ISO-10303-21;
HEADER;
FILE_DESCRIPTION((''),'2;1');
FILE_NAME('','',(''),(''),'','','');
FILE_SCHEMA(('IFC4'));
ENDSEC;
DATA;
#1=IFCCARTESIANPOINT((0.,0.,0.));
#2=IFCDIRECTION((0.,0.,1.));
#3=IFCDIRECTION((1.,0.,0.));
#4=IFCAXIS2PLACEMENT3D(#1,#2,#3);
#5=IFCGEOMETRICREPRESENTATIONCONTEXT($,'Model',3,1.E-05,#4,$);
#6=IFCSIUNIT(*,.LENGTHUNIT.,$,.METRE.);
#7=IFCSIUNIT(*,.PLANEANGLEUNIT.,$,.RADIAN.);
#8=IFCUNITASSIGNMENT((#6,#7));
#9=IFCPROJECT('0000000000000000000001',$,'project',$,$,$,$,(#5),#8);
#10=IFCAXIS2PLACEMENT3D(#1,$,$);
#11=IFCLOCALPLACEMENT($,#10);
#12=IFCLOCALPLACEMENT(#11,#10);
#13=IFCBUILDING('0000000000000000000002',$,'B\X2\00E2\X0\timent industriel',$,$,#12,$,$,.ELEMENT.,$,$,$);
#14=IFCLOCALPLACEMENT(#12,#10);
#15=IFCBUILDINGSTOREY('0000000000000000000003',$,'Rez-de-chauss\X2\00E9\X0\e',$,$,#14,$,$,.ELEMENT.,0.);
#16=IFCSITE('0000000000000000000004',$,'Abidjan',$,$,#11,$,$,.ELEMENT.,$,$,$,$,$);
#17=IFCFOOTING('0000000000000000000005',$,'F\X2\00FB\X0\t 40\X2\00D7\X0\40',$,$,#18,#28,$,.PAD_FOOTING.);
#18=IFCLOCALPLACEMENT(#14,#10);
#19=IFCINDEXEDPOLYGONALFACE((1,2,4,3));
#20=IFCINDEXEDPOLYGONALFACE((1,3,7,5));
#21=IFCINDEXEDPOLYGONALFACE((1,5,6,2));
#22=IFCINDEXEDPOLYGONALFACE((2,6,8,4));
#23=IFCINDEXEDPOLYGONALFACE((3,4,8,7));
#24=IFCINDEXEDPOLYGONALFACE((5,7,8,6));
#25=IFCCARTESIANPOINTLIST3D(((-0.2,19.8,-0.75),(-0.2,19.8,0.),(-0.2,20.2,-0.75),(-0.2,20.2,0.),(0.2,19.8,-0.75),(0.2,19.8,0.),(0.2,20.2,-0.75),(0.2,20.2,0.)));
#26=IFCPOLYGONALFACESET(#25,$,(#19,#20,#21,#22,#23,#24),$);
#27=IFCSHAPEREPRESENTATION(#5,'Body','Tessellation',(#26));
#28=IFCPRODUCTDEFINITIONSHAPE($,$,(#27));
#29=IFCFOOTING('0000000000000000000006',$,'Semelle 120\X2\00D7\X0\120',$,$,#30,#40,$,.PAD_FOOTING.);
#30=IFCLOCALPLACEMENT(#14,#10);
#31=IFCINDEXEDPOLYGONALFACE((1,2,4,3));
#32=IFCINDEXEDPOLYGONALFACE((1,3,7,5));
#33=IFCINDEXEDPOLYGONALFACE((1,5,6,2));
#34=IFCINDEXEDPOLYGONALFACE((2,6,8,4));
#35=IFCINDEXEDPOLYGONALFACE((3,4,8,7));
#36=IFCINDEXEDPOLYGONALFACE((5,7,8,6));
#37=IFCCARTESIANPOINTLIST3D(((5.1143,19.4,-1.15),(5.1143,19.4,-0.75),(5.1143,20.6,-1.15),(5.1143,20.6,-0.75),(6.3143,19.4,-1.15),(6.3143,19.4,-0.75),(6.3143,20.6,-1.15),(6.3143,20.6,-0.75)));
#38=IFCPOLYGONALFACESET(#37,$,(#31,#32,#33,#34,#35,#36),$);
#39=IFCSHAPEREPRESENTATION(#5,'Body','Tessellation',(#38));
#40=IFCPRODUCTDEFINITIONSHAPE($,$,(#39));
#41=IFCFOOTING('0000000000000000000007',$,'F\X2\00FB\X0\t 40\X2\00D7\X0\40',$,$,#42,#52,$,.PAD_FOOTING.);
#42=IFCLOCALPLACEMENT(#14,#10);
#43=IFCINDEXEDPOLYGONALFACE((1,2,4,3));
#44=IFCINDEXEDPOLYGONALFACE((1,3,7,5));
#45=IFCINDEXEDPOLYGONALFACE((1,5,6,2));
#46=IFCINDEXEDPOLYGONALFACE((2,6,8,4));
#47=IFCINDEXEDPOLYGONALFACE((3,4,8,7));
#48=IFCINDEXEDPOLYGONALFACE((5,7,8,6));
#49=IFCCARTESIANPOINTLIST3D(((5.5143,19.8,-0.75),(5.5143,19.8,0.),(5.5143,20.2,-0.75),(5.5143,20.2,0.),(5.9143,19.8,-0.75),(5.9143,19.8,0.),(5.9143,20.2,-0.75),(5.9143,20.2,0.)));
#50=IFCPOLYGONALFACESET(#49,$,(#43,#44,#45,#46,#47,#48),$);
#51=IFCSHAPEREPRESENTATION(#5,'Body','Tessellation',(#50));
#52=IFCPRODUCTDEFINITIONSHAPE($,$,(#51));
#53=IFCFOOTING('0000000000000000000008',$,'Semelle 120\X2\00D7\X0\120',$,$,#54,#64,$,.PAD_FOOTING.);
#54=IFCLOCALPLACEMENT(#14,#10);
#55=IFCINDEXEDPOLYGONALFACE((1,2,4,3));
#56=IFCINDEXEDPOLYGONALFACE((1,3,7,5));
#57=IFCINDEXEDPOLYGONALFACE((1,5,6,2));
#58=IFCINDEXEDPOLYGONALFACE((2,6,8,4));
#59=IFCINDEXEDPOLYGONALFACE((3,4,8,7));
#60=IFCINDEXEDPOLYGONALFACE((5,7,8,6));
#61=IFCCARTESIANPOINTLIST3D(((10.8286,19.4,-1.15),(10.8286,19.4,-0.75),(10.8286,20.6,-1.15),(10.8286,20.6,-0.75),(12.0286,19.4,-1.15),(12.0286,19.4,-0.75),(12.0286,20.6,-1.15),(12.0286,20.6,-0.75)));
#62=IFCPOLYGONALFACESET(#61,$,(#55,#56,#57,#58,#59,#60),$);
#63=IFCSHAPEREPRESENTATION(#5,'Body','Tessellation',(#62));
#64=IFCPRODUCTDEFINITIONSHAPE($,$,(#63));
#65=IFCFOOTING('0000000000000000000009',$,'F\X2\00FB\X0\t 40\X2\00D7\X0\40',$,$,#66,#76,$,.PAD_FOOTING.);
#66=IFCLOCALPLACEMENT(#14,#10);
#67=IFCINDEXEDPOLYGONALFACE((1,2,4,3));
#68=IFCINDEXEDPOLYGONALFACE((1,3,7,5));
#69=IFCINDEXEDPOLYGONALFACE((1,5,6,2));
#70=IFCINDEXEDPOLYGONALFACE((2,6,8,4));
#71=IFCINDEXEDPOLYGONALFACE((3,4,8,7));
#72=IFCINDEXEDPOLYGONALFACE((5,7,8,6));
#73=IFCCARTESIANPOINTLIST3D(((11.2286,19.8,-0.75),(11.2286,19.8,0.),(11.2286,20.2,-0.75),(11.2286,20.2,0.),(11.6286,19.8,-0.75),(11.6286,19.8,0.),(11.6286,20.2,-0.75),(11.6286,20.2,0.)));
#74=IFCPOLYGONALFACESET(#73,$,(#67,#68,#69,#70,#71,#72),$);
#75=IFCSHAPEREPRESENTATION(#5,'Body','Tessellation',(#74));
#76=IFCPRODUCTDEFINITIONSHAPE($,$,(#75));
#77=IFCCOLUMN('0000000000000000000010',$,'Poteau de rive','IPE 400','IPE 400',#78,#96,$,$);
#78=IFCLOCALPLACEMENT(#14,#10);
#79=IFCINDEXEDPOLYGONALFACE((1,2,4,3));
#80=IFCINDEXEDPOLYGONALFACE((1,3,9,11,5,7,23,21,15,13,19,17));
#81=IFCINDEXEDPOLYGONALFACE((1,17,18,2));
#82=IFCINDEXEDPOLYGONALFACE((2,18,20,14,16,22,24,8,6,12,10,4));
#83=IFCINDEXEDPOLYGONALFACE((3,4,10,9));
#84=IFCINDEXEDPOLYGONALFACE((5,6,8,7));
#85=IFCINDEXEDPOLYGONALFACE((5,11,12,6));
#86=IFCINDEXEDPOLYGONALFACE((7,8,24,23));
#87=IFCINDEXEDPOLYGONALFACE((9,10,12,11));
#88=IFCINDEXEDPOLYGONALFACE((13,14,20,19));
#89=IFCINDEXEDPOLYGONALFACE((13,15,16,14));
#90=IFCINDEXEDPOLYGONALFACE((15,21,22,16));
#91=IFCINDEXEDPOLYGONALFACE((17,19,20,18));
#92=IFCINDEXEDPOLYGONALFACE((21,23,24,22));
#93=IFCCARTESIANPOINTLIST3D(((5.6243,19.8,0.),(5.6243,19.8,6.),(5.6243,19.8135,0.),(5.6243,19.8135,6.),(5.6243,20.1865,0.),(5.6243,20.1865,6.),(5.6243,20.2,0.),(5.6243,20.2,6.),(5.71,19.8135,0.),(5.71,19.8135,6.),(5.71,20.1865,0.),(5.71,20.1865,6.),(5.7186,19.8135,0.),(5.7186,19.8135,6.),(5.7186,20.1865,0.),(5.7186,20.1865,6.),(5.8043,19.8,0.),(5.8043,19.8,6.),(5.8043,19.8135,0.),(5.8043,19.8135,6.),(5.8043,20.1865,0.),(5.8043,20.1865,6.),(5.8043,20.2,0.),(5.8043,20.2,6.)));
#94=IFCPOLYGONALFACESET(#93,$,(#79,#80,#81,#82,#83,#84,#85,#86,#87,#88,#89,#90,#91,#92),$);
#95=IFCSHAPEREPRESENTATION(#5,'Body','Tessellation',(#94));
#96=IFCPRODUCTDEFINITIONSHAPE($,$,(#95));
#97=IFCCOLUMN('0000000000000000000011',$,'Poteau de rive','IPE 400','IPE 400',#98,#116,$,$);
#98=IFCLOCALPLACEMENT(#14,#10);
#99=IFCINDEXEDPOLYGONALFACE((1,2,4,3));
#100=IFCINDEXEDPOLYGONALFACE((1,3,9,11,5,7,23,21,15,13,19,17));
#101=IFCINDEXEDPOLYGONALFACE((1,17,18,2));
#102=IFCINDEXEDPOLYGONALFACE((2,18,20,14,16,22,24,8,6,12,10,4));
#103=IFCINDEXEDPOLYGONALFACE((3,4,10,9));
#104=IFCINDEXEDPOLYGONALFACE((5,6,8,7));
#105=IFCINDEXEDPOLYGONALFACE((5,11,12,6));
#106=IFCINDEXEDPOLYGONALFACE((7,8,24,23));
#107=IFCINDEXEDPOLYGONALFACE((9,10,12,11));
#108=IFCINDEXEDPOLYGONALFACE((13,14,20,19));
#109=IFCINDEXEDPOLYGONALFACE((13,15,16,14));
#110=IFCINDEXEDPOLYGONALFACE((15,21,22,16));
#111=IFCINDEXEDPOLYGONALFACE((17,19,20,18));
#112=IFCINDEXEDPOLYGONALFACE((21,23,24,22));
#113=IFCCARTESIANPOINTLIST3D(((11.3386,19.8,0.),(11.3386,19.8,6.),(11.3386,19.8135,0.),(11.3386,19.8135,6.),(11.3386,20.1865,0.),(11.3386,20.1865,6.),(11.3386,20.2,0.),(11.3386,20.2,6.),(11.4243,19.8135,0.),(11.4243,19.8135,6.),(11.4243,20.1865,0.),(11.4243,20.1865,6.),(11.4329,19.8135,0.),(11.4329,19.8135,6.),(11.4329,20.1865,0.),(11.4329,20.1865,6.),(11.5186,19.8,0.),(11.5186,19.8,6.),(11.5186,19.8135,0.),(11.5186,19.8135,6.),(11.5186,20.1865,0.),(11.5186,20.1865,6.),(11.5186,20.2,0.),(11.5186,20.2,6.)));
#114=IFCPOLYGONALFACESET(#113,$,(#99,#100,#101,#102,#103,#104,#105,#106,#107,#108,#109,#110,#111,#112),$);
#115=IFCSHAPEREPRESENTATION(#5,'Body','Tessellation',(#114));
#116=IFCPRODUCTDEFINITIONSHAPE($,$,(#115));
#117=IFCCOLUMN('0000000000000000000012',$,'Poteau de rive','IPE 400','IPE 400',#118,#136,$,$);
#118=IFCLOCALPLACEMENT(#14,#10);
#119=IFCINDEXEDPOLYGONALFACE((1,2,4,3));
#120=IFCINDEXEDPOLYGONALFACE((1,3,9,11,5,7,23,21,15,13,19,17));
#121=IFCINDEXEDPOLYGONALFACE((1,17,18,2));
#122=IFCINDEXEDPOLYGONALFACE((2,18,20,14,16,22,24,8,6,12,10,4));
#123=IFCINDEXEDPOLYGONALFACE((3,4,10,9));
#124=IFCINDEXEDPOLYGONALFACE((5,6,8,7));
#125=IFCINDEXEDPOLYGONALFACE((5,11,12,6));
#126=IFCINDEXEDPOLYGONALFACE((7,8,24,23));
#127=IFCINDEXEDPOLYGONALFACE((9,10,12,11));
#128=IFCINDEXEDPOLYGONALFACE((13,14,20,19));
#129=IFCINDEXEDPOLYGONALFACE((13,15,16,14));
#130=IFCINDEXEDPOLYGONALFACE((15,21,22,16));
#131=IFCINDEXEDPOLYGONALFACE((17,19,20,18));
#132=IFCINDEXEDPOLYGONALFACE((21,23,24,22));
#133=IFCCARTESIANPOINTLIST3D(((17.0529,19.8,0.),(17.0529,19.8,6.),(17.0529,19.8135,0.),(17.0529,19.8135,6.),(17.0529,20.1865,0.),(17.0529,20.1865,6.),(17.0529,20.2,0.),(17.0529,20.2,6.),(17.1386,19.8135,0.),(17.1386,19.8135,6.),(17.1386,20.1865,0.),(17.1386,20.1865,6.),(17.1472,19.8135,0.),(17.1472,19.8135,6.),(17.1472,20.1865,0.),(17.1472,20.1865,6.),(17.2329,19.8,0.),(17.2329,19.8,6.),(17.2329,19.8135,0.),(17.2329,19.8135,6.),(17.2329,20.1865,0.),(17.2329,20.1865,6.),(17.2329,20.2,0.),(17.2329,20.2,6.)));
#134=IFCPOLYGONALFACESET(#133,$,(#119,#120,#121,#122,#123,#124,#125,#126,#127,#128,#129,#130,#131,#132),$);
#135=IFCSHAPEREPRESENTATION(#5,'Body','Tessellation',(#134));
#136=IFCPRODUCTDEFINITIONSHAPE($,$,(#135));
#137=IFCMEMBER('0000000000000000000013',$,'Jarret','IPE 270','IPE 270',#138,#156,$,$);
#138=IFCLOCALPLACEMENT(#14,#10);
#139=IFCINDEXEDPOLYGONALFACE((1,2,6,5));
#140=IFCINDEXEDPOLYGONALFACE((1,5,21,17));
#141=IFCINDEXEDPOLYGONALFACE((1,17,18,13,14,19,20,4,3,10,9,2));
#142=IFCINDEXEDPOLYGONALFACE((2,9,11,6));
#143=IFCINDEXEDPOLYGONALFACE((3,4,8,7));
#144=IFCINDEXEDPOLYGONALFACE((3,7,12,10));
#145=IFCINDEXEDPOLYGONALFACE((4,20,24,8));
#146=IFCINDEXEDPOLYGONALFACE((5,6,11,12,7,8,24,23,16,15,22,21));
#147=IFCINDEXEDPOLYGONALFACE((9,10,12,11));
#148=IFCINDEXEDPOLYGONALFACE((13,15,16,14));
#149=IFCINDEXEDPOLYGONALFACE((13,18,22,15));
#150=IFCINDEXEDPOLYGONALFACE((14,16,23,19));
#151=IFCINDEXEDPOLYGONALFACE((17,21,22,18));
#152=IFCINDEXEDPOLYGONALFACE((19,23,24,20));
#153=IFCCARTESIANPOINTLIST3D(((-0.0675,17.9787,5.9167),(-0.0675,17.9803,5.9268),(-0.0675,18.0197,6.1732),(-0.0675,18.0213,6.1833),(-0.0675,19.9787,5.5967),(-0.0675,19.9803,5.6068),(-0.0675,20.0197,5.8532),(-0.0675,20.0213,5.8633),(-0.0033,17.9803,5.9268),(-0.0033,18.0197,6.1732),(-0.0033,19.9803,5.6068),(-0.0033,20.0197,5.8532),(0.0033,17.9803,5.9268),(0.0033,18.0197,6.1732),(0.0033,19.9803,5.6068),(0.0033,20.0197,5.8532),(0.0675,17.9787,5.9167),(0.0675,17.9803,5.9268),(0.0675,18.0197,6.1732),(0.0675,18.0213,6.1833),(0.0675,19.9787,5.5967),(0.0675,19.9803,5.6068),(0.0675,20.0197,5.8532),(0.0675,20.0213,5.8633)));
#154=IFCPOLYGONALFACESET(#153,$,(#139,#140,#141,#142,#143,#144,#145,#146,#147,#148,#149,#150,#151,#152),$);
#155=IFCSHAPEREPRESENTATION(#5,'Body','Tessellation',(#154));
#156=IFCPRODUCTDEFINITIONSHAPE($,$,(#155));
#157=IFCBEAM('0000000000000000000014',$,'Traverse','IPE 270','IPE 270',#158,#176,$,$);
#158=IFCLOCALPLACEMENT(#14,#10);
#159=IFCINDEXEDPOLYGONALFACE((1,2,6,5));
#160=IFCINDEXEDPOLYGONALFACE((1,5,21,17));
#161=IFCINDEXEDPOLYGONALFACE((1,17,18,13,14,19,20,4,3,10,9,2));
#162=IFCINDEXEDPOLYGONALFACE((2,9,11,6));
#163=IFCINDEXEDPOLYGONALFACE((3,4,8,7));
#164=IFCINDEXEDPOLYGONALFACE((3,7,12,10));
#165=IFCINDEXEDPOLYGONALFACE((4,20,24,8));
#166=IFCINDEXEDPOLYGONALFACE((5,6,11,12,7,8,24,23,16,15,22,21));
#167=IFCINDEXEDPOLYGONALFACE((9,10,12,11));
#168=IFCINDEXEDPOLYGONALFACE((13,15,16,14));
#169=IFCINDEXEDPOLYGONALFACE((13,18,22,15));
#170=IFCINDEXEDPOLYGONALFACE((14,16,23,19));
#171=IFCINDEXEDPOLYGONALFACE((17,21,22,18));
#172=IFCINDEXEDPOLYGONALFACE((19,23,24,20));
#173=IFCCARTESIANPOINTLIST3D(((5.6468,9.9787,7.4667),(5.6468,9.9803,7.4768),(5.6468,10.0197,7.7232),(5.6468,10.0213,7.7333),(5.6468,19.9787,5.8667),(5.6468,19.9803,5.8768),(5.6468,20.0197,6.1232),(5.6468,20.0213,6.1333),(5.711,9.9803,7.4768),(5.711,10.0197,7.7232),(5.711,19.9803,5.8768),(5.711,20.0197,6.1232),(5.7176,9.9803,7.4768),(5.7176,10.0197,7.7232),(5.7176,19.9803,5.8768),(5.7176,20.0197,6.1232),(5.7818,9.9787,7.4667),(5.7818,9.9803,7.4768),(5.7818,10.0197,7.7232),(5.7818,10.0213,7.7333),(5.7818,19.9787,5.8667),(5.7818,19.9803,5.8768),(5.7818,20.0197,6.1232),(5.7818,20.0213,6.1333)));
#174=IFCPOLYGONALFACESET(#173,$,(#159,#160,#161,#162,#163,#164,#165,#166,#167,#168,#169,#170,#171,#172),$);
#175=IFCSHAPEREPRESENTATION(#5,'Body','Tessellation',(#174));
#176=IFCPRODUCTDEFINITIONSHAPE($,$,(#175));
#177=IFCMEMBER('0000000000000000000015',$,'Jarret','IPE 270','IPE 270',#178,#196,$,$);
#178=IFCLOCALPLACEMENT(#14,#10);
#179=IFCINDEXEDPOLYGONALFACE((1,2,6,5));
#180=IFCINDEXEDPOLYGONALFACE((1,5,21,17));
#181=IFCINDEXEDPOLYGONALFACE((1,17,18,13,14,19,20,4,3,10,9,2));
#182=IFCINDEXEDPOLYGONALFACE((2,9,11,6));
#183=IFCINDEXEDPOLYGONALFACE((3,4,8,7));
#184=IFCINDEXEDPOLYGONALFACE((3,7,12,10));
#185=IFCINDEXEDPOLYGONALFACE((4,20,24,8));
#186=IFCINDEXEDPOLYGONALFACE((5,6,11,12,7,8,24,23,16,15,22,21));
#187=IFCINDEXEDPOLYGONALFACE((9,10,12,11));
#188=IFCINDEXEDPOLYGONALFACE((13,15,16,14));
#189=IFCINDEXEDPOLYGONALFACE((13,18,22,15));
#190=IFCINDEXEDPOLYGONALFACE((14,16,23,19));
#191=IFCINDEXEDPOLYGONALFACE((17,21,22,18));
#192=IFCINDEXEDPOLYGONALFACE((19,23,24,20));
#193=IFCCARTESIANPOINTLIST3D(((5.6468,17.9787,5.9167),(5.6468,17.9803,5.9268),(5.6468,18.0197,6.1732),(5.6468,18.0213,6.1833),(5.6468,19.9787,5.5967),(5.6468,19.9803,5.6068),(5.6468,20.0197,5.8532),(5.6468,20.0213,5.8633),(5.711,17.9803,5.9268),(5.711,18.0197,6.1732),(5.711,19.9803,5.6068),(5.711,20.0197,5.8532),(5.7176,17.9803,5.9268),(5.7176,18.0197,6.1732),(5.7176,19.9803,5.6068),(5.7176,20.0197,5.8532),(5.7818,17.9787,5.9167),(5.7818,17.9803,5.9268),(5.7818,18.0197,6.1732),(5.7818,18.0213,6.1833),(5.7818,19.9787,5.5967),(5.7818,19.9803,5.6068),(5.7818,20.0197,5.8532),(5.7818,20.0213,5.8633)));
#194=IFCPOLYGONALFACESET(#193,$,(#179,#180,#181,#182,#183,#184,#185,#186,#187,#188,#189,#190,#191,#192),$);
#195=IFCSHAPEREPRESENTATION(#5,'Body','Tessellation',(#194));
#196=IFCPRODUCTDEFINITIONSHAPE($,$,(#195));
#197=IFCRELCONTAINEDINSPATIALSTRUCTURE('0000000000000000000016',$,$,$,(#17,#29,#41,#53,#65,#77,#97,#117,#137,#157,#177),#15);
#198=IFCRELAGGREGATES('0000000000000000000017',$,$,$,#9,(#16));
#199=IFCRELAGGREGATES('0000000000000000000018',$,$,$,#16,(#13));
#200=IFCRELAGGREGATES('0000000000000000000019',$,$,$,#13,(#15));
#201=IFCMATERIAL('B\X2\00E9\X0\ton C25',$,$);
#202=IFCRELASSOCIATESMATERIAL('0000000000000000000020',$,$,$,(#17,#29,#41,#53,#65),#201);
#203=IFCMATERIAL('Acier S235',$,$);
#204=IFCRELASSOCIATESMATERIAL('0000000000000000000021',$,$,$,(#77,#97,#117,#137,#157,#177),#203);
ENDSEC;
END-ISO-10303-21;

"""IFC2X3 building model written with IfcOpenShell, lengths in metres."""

from ifc_helpers import new_model, si_unit, frame, origin, origin_with_axes, origin_2d, place, context, project, spatial, rectangle, i_section, extrude, material, element, save


model = new_model("IFC2X3")

# Units and contexts
model_context = context("Model", 3, precision=1e-05, world=origin_with_axes())
ifc_project = project(units=[si_unit("LENGTHUNIT", "METRE"), si_unit("PLANEANGLEUNIT", "RADIAN")], contexts=[model_context])

# Site, building, storey
site_placement = place(None, origin())
site = spatial("IfcSite", under=ifc_project, at=site_placement, Name="Abidjan", CompositionType="ELEMENT")
building_placement = place(site_placement, origin())
building = spatial("IfcBuilding", under=site, at=building_placement, Name="Bâtiment industriel", CompositionType="ELEMENT")
storey_placement = place(building_placement, origin())
storey = spatial("IfcBuildingStorey", under=building, at=storey_placement, Name="Rez-de-chaussée", CompositionType="ELEMENT", Elevation=0.0)

# Footings
ifc_material_1 = material(Name="Béton C25")
footing_1_placement = place(storey_placement, frame((0.0, 20.0, -0.75), z_axis=(0.0, 0.0, 1.0), x_axis=(1.0, 0.0, 0.0)))
element("IfcFooting", 1, at=footing_1_placement, inside=storey, material=ifc_material_1, Name="Fût 40×40", PredefinedType="PAD_FOOTING", context=model_context, shape_type="SweptSolid", body=[
    extrude(rectangle(XDim=0.4, YDim=0.4, at=origin_2d()), origin(), (0.0, 0.0, 1.0), 0.75),
])
footing_2_placement = place(storey_placement, frame((5.7143, 20.0, -1.15), z_axis=(0.0, 0.0, 1.0), x_axis=(1.0, 0.0, 0.0)))
element("IfcFooting", 2, at=footing_2_placement, inside=storey, material=ifc_material_1, Name="Semelle 120×120", PredefinedType="PAD_FOOTING", context=model_context, shape_type="SweptSolid", body=[
    extrude(rectangle(XDim=1.2, YDim=1.2, at=origin_2d()), origin(), (0.0, 0.0, 1.0), 0.4),
])
footing_3_placement = place(storey_placement, frame((5.7143, 20.0, -0.75), z_axis=(0.0, 0.0, 1.0), x_axis=(1.0, 0.0, 0.0)))
element("IfcFooting", 3, at=footing_3_placement, inside=storey, material=ifc_material_1, Name="Fût 40×40", PredefinedType="PAD_FOOTING", context=model_context, shape_type="SweptSolid", body=[
    extrude(rectangle(XDim=0.4, YDim=0.4, at=origin_2d()), origin(), (0.0, 0.0, 1.0), 0.75),
])
footing_4_placement = place(storey_placement, frame((11.4286, 20.0, -1.15), z_axis=(0.0, 0.0, 1.0), x_axis=(1.0, 0.0, 0.0)))
element("IfcFooting", 4, at=footing_4_placement, inside=storey, material=ifc_material_1, Name="Semelle 120×120", PredefinedType="PAD_FOOTING", context=model_context, shape_type="SweptSolid", body=[
    extrude(rectangle(XDim=1.2, YDim=1.2, at=origin_2d()), origin(), (0.0, 0.0, 1.0), 0.4),
])
footing_5_placement = place(storey_placement, frame((11.4286, 20.0, -0.75), z_axis=(0.0, 0.0, 1.0), x_axis=(1.0, 0.0, 0.0)))
element("IfcFooting", 5, at=footing_5_placement, inside=storey, material=ifc_material_1, Name="Fût 40×40", PredefinedType="PAD_FOOTING", context=model_context, shape_type="SweptSolid", body=[
    extrude(rectangle(XDim=0.4, YDim=0.4, at=origin_2d()), origin(), (0.0, 0.0, 1.0), 0.75),
])

# Columns
ifc_material_2 = material(Name="Acier S235")
for number, where, z_axis, x_axis, name in (
    (6, (5.7143, 20.0, 0.0), (0.0, 0.0, 1.0), (1.0, 0.0, 0.0), "Poteau de rive"),
    (7, (11.4286, 20.0, 0.0), (0.0, 0.0, 1.0), (1.0, 0.0, 0.0), "Poteau de rive"),
    (8, (17.1429, 20.0, 0.0), (0.0, 0.0, 1.0), (1.0, 0.0, 0.0), "Poteau de rive"),
):
    element("IfcColumn", number, at=place(storey_placement, frame(where, z_axis=z_axis, x_axis=x_axis)), inside=storey, material=ifc_material_2, Name=name, Description="IPE 400", ObjectType="IPE 400", context=model_context, shape_type="SweptSolid", body=[
        extrude(i_section(OverallWidth=0.18, OverallDepth=0.4, WebThickness=0.0086, FlangeThickness=0.0135, at=origin_2d()), origin(), (0.0, 0.0, 1.0), 6.0),
    ])

# Member
member_1_placement = place(storey_placement, frame((0.0, 20.0, 5.73), z_axis=(0.0, -0.98744, 0.15799), x_axis=(1.0, 0.0, 0.0)))
element("IfcMember", 9, at=member_1_placement, inside=storey, material=ifc_material_2, Name="Jarret", Description="IPE 270", ObjectType="IPE 270", context=model_context, shape_type="SweptSolid", body=[
    extrude(i_section(OverallWidth=0.135, OverallDepth=0.27, WebThickness=0.0066, FlangeThickness=0.0102, at=origin_2d()), origin(), (0.0, 0.0, 1.0), 2.0254),
])

# Beam
beam_1_placement = place(storey_placement, frame((5.7143, 10.0, 7.6), z_axis=(0.0, 0.98744, -0.15799), x_axis=(1.0, 0.0, 0.0)))
element("IfcBeam", 10, at=beam_1_placement, inside=storey, material=ifc_material_2, Name="Traverse", Description="IPE 270", ObjectType="IPE 270", context=model_context, shape_type="SweptSolid", body=[
    extrude(i_section(OverallWidth=0.135, OverallDepth=0.27, WebThickness=0.0066, FlangeThickness=0.0102, at=origin_2d()), origin(), (0.0, 0.0, 1.0), 10.1272),
])

# Member
member_2_placement = place(storey_placement, frame((5.7143, 20.0, 5.73), z_axis=(0.0, -0.98744, 0.15799), x_axis=(1.0, 0.0, 0.0)))
element("IfcMember", 11, at=member_2_placement, inside=storey, material=ifc_material_2, Name="Jarret", Description="IPE 270", ObjectType="IPE 270", context=model_context, shape_type="SweptSolid", body=[
    extrude(i_section(OverallWidth=0.135, OverallDepth=0.27, WebThickness=0.0066, FlangeThickness=0.0102, at=origin_2d()), origin(), (0.0, 0.0, 1.0), 2.0254),
])

save(model, "model.ifc")
